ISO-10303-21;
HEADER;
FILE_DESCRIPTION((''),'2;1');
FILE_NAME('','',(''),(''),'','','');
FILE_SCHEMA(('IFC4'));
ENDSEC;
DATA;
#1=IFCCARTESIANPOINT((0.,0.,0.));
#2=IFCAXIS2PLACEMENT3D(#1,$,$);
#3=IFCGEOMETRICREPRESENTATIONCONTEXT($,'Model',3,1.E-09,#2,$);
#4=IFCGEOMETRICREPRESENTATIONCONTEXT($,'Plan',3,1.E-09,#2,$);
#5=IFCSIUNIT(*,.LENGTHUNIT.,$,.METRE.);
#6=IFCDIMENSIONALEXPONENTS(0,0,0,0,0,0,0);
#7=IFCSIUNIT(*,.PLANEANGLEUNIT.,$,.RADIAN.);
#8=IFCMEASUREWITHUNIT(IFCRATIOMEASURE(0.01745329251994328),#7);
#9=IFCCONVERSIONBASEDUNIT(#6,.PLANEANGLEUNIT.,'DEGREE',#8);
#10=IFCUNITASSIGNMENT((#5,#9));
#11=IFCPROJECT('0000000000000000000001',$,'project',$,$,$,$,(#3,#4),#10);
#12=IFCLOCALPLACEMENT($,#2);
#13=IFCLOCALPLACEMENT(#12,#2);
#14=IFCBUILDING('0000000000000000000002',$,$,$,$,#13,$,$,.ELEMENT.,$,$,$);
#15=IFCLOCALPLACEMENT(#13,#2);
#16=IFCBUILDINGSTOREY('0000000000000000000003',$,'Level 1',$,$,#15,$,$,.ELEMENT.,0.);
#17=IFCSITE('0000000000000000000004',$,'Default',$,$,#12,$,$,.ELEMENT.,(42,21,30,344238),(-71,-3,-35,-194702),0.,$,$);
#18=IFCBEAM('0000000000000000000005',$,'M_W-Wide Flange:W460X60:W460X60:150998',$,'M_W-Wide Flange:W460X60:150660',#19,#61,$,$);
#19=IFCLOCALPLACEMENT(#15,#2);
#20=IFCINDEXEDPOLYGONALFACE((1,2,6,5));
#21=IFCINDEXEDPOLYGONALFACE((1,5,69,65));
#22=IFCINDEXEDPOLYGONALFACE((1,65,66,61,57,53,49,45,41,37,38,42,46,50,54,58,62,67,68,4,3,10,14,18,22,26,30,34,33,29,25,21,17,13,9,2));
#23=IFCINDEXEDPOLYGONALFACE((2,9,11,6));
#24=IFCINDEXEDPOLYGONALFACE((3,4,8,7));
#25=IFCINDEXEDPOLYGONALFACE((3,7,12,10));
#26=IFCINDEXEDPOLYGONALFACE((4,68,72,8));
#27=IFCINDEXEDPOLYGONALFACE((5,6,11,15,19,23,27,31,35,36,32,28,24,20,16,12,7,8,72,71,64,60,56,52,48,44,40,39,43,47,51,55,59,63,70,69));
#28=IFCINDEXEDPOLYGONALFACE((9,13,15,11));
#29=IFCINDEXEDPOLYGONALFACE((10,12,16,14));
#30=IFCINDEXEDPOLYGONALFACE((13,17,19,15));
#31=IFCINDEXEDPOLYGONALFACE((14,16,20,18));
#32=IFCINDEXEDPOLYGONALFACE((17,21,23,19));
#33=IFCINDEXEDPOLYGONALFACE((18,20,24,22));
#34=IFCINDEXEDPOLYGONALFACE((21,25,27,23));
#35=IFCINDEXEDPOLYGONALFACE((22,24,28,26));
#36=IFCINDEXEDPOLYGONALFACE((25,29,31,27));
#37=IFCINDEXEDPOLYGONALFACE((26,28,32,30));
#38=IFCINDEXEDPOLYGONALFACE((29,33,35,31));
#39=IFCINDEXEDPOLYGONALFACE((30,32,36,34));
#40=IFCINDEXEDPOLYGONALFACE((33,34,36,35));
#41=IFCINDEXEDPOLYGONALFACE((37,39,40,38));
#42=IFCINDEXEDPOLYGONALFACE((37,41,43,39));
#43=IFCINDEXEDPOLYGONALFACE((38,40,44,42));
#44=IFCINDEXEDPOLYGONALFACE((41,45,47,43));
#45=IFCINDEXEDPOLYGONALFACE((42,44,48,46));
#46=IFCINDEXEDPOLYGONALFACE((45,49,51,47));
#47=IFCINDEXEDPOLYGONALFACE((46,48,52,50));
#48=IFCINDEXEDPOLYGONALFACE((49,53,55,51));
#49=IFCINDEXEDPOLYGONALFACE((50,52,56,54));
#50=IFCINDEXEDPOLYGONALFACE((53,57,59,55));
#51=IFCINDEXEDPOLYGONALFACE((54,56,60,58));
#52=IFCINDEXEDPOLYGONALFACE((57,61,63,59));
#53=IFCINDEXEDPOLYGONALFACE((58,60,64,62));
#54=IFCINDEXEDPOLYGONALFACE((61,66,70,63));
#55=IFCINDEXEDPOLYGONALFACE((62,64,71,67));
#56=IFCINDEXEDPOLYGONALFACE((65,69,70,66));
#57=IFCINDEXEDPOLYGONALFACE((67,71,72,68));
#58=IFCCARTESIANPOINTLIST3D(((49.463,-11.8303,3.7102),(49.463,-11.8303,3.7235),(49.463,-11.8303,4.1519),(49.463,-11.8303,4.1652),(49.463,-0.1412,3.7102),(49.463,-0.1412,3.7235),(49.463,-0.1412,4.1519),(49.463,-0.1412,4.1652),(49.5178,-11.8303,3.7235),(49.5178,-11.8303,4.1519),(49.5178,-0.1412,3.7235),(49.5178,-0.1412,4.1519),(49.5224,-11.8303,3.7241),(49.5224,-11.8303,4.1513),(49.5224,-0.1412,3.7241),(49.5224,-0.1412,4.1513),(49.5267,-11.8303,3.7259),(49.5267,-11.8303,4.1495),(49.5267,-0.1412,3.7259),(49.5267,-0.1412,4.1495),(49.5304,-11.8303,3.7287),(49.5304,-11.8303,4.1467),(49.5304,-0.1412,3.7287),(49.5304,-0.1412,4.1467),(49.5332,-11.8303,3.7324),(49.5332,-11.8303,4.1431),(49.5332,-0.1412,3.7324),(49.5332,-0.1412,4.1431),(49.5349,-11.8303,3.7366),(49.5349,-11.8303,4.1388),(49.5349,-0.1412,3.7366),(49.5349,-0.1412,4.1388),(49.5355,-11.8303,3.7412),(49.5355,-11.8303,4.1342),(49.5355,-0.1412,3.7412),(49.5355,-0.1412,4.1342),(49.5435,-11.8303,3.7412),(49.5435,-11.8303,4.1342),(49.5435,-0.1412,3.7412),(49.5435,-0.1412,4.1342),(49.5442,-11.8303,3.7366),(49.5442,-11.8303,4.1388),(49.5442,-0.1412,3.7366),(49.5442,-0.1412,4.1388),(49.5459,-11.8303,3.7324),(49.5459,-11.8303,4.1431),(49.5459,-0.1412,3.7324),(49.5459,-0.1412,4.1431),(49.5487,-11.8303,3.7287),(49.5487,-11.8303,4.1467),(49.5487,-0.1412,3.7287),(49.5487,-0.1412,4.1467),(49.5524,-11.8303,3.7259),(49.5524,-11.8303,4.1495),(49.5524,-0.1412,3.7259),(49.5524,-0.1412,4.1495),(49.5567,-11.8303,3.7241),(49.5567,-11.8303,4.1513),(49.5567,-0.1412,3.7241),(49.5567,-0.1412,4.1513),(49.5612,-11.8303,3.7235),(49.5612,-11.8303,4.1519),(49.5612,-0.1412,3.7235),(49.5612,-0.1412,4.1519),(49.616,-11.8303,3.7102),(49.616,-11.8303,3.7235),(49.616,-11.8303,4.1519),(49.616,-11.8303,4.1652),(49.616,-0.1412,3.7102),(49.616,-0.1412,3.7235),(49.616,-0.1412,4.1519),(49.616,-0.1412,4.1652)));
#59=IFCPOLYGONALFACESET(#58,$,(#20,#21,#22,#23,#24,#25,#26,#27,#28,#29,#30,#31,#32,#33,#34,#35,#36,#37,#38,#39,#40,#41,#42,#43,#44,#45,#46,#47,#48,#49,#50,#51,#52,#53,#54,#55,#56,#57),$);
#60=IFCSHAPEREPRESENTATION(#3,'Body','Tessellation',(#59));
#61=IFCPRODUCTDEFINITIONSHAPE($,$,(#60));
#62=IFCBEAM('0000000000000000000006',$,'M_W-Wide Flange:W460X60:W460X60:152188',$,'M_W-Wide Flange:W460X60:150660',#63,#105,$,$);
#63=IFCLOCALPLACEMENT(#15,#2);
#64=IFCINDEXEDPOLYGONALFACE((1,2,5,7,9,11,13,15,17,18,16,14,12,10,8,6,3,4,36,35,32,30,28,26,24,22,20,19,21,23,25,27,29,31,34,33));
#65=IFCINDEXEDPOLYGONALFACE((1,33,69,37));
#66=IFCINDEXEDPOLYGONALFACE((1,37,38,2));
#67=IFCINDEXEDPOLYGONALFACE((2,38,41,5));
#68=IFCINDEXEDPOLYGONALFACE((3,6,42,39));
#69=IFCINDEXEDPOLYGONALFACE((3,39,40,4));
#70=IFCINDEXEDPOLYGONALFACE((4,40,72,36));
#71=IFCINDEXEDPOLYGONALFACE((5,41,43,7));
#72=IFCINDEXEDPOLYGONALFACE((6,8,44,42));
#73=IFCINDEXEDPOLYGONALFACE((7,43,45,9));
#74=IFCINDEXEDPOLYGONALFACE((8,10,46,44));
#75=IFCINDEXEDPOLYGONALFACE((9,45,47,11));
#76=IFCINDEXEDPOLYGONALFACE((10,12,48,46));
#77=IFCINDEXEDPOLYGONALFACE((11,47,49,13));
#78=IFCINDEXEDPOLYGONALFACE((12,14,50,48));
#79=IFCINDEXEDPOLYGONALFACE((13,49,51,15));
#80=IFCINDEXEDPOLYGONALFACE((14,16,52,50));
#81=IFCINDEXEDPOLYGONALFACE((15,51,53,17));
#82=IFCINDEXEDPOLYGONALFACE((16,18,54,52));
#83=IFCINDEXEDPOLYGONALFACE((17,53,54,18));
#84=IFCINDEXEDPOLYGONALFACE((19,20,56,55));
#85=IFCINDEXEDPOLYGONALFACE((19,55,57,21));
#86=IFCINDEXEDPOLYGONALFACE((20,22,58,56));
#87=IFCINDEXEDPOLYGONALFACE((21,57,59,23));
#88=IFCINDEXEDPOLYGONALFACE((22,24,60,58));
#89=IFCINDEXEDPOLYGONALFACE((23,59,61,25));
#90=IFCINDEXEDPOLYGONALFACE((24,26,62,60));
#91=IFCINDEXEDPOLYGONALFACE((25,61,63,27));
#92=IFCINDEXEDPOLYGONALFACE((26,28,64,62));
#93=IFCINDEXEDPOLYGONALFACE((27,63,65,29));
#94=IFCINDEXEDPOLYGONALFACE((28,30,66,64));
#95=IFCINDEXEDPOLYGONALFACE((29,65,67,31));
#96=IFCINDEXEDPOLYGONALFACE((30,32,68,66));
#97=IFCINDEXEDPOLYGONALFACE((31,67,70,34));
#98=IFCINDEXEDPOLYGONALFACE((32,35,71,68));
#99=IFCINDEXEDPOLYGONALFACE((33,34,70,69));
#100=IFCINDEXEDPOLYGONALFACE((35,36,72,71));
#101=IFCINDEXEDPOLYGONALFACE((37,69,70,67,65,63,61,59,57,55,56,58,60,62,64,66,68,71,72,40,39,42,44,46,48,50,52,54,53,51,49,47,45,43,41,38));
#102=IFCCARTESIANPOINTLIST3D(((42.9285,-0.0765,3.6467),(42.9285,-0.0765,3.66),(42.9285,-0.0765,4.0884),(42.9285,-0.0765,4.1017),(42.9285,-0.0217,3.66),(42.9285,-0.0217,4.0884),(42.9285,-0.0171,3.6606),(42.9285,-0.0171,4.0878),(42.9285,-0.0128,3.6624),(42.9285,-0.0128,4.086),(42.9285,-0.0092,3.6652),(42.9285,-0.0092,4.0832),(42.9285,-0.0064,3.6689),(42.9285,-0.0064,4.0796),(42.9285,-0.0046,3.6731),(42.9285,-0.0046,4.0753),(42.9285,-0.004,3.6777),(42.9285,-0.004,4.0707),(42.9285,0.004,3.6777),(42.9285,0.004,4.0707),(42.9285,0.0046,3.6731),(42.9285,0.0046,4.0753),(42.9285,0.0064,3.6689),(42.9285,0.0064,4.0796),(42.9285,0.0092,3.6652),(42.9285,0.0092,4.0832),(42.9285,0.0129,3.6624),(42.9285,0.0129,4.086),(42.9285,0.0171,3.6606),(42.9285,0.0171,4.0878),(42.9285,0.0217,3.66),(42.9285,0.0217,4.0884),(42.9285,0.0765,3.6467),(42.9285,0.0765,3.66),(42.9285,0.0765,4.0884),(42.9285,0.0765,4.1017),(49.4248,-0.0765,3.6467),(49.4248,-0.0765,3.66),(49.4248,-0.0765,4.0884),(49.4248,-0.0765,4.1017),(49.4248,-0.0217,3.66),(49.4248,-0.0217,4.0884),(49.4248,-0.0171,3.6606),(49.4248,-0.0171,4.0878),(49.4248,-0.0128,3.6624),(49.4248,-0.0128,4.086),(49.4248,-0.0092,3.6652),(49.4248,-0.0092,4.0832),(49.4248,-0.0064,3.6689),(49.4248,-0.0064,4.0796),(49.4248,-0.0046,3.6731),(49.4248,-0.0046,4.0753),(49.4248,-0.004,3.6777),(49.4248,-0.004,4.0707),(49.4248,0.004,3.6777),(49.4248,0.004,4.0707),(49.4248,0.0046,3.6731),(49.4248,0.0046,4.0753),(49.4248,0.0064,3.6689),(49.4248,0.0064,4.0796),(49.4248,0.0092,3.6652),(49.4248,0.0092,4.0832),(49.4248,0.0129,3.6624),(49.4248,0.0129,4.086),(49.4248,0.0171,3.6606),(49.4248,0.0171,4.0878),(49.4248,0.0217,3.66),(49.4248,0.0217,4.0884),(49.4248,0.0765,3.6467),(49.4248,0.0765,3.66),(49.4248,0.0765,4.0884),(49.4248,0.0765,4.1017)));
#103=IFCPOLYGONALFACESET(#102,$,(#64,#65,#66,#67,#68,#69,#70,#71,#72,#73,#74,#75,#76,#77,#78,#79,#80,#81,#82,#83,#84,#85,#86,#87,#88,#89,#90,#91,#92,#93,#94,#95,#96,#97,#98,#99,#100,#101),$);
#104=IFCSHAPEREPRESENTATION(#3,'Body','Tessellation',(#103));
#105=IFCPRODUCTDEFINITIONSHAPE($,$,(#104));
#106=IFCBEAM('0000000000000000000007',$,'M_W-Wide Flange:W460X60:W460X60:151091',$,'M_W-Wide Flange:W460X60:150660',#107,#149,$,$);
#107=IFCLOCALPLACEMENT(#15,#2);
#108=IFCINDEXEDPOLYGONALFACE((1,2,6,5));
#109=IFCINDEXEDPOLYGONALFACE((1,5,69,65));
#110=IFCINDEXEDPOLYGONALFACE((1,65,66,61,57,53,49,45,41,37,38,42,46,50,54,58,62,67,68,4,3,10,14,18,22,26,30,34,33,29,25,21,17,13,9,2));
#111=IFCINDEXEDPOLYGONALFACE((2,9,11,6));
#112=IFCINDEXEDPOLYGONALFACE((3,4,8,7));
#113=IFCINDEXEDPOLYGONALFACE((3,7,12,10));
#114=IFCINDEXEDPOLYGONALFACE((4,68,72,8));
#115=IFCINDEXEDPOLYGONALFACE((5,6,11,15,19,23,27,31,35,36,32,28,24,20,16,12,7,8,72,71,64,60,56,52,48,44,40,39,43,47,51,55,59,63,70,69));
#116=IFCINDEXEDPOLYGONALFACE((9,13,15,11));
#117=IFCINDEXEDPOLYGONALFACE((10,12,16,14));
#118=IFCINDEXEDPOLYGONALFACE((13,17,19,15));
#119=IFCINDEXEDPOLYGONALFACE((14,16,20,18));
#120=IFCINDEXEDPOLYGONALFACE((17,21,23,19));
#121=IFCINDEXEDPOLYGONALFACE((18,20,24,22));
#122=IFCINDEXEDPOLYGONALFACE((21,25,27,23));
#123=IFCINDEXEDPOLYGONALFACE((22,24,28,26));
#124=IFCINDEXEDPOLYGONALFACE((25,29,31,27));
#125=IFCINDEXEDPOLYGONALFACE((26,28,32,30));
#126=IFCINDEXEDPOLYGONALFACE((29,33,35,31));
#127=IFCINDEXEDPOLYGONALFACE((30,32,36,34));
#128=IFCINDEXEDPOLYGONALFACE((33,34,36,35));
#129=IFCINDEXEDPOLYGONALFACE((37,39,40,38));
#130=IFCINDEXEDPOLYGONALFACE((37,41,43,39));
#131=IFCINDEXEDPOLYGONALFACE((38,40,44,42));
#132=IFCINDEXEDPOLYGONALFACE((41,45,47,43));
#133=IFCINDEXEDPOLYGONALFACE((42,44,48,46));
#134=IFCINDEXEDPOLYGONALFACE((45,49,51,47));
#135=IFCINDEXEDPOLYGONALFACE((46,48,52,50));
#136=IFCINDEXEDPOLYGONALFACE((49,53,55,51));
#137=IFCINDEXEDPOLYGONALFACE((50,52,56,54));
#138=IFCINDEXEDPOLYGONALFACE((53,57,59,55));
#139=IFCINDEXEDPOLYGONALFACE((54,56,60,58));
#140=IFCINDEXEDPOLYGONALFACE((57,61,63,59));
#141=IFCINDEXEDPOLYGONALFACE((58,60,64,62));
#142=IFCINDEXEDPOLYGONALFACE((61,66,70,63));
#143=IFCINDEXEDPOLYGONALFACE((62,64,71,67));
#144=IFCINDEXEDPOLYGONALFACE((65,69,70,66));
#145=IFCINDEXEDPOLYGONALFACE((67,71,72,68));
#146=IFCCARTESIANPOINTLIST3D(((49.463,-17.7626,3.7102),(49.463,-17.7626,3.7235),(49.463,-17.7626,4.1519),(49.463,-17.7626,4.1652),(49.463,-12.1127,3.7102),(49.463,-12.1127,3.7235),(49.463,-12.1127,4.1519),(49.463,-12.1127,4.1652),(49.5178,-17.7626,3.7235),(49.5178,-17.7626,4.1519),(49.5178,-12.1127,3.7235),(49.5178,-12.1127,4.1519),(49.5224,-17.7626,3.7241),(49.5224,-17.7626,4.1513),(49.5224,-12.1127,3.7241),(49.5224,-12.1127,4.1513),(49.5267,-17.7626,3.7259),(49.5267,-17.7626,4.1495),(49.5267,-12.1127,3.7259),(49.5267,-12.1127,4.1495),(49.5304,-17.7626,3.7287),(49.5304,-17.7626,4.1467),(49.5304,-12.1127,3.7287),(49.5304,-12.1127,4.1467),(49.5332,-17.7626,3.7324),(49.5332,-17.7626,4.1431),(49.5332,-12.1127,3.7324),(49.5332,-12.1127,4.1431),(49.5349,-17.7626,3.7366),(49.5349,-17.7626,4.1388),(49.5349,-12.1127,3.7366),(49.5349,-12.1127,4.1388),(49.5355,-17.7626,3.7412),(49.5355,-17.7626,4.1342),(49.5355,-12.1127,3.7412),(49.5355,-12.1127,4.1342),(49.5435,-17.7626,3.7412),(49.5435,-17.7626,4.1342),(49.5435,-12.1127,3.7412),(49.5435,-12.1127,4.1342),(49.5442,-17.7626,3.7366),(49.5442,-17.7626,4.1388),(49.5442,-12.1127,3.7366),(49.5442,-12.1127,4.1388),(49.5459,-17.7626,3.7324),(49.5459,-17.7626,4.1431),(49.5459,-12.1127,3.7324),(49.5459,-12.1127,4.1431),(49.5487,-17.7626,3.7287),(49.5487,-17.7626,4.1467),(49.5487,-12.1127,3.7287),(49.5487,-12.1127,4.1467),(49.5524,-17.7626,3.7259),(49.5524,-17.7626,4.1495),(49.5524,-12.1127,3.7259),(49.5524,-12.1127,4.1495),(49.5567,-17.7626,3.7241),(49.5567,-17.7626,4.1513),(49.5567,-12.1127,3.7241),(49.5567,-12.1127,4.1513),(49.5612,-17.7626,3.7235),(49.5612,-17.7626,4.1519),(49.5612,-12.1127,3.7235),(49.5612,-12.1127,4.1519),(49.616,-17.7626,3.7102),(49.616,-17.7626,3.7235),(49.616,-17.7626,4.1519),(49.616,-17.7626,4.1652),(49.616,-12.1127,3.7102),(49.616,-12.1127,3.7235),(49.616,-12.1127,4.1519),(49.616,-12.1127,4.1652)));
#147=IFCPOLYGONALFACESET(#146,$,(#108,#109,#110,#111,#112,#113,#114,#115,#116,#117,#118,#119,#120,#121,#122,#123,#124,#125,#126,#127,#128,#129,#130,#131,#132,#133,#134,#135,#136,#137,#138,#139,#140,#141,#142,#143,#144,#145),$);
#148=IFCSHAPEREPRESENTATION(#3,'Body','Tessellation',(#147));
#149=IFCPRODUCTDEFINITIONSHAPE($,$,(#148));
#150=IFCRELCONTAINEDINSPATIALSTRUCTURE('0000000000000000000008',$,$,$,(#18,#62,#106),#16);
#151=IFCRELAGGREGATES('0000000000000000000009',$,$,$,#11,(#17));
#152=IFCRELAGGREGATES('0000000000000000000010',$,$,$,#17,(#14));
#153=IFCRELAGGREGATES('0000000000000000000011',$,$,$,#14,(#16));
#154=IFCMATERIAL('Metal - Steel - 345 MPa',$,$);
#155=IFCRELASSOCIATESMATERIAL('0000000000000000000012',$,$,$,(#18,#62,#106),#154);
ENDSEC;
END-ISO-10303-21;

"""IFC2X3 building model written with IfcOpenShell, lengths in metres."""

from ifc_helpers import new_model, entity, si_unit, converted_unit, frame, frame_2d, origin, place, context, project, spatial, polyline, circle_curve, parameter, trimmed, segment, composite_curve, outline, extrude, material, element, save


model = new_model("IFC2X3")

# Units and contexts
model_context = context("Model", 3, precision=1e-09, world=origin())
plan_context = context("Plan", 3, precision=1e-09, world=origin())
ifc_project = project(units=[si_unit("LENGTHUNIT", "METRE"), converted_unit("PLANEANGLEUNIT", "DEGREE", entity("IfcRatioMeasure", 0.01745329251994328), si_unit("PLANEANGLEUNIT", "RADIAN"), dimensions=[0, 0, 0, 0, 0, 0, 0])], contexts=[model_context, plan_context])

# Site, building, storey
site_placement = place(None, origin())
site = spatial("IfcSite", under=ifc_project, at=site_placement, Name="Default", CompositionType="ELEMENT", RefLatitude=(42, 21, 30, 344238), RefLongitude=(-71, -3, -35, -194702), RefElevation=0.0)
building_placement = place(site_placement, origin())
building = spatial("IfcBuilding", under=site, at=building_placement, CompositionType="ELEMENT")
storey_placement = place(building_placement, origin())
storey = spatial("IfcBuildingStorey", under=building, at=storey_placement, Name="Level 1", CompositionType="ELEMENT", Elevation=0.0)

# Beams
ifc_material = material(Name="Metal - Steel - 345 MPa")
beam_1_placement = place(storey_placement, frame((49.5395, 0.0, 4.2672), z_axis=(0.0, 0.0, 1.0), x_axis=(-1.0, 0.0, 0.0)))
element("IfcBeam", 1, at=beam_1_placement, inside=storey, material=ifc_material, Name="M_W-Wide Flange:W460X60:W460X60:150998", ObjectType="M_W-Wide Flange:W460X60:150660", context=model_context, shape_type="SweptSolid", body=[
    extrude(outline(composite_curve([segment(polyline([(0.2142, -0.0765), (0.2275, -0.0765)]), True, "CONTINUOUS"), segment(polyline([(0.2275, -0.0765), (0.2275, 0.0765)]), True, "CONTINUOUS"), segment(polyline([(0.2275, 0.0765), (0.2142, 0.0765)]), True, "CONTINUOUS"), segment(polyline([(0.2142, 0.0765), (0.2142, 0.0217)]), True, "CONTINUOUS"), segment(trimmed(circle_curve(frame_2d((0.1965, 0.0217), x_axis=(0.0, 1.0)), 0.0177), [parameter(180.0)], [parameter(270.0)], True, "PARAMETER"), False, "CONTINUOUS"), segment(polyline([(0.1965, 0.004), (-0.1965, 0.004)]), True, "CONTINUOUS"), segment(trimmed(circle_curve(frame_2d((-0.1965, 0.0217), x_axis=(0.0, 1.0)), 0.0177), [parameter(90.0)], [parameter(180.0)], True, "PARAMETER"), False, "CONTINUOUS"), segment(polyline([(-0.2142, 0.0217), (-0.2142, 0.0765)]), True, "CONTINUOUS"), segment(polyline([(-0.2142, 0.0765), (-0.2275, 0.0765)]), True, "CONTINUOUS"), segment(polyline([(-0.2275, 0.0765), (-0.2275, -0.0765)]), True, "CONTINUOUS"), segment(polyline([(-0.2275, -0.0765), (-0.2142, -0.0765)]), True, "CONTINUOUS"), segment(polyline([(-0.2142, -0.0765), (-0.2142, -0.0217)]), True, "CONTINUOUS"), segment(trimmed(circle_curve(frame_2d((-0.1965, -0.0217), x_axis=(0.0, 1.0)), 0.0177), [parameter(360.0)], [parameter(90.0)], True, "PARAMETER"), False, "CONTINUOUS"), segment(polyline([(-0.1965, -0.004), (0.1965, -0.004)]), True, "CONTINUOUS"), segment(trimmed(circle_curve(frame_2d((0.1965, -0.0217), x_axis=(0.0, 1.0)), 0.0177), [parameter(270.0)], [parameter(0.0)], True, "PARAMETER"), False, "CONTINUOUS"), segment(polyline([(0.2142, -0.0217), (0.2142, -0.0765)]), True, "CONTINUOUS")], self_intersect=False)), frame((0.0, 11.8303, -0.3295), z_axis=(0.0, -1.0, 0.0), x_axis=(0.0, 0.0, -1.0)), (0.0, 0.0, 1.0), 11.6891),
])
beam_2_placement = place(storey_placement, frame((42.8138, 0.0, 4.2672), z_axis=(0.0, 0.0, 1.0), x_axis=(0.0, -1.0, 0.0)))
element("IfcBeam", 2, at=beam_2_placement, inside=storey, material=ifc_material, Name="M_W-Wide Flange:W460X60:W460X60:152188", ObjectType="M_W-Wide Flange:W460X60:150660", context=model_context, shape_type="SweptSolid", body=[
    extrude(outline(composite_curve([segment(polyline([(-0.0765, -0.2142), (-0.0765, -0.2275)]), True, "CONTINUOUS"), segment(polyline([(-0.0765, -0.2275), (0.0765, -0.2275)]), True, "CONTINUOUS"), segment(polyline([(0.0765, -0.2275), (0.0765, -0.2142)]), True, "CONTINUOUS"), segment(polyline([(0.0765, -0.2142), (0.0217, -0.2142)]), True, "CONTINUOUS"), segment(trimmed(circle_curve(frame_2d((0.0217, -0.1965), x_axis=(1.0, 0.0)), 0.0177), [parameter(180.0)], [parameter(270.0)], True, "PARAMETER"), False, "CONTINUOUS"), segment(polyline([(0.004, -0.1965), (0.004, 0.1965)]), True, "CONTINUOUS"), segment(trimmed(circle_curve(frame_2d((0.0217, 0.1965), x_axis=(1.0, 0.0)), 0.0177), [parameter(90.0)], [parameter(180.0)], True, "PARAMETER"), False, "CONTINUOUS"), segment(polyline([(0.0217, 0.2142), (0.0765, 0.2142)]), True, "CONTINUOUS"), segment(polyline([(0.0765, 0.2142), (0.0765, 0.2275)]), True, "CONTINUOUS"), segment(polyline([(0.0765, 0.2275), (-0.0765, 0.2275)]), True, "CONTINUOUS"), segment(polyline([(-0.0765, 0.2275), (-0.0765, 0.2142)]), True, "CONTINUOUS"), segment(polyline([(-0.0765, 0.2142), (-0.0217, 0.2142)]), True, "CONTINUOUS"), segment(trimmed(circle_curve(frame_2d((-0.0217, 0.1965), x_axis=(1.0, 0.0)), 0.0177), [parameter(360.0)], [parameter(90.0)], True, "PARAMETER"), False, "CONTINUOUS"), segment(polyline([(-0.004, 0.1965), (-0.004, -0.1965)]), True, "CONTINUOUS"), segment(trimmed(circle_curve(frame_2d((-0.0217, -0.1965), x_axis=(1.0, 0.0)), 0.0177), [parameter(270.0)], [parameter(0.0)], True, "PARAMETER"), False, "CONTINUOUS"), segment(polyline([(-0.0217, -0.2142), (-0.0765, -0.2142)]), True, "CONTINUOUS")], self_intersect=False)), frame((0.0, 0.1147, -0.393), z_axis=(0.0, -1.0, 0.0), x_axis=(1.0, 0.0, 0.0)), (0.0, 0.0, -1.0), 6.4963),
])
beam_3_placement = place(storey_placement, frame((49.5395, -11.9715, 4.2672), z_axis=(0.0, 0.0, 1.0), x_axis=(-1.0, 0.0, 0.0)))
element("IfcBeam", 3, at=beam_3_placement, inside=storey, material=ifc_material, Name="M_W-Wide Flange:W460X60:W460X60:151091", ObjectType="M_W-Wide Flange:W460X60:150660", context=model_context, shape_type="SweptSolid", body=[
    extrude(outline(composite_curve([segment(polyline([(0.2142, -0.0765), (0.2275, -0.0765)]), True, "CONTINUOUS"), segment(polyline([(0.2275, -0.0765), (0.2275, 0.0765)]), True, "CONTINUOUS"), segment(polyline([(0.2275, 0.0765), (0.2142, 0.0765)]), True, "CONTINUOUS"), segment(polyline([(0.2142, 0.0765), (0.2142, 0.0217)]), True, "CONTINUOUS"), segment(trimmed(circle_curve(frame_2d((0.1965, 0.0217), x_axis=(0.0, 1.0)), 0.0177), [parameter(180.0)], [parameter(270.0)], True, "PARAMETER"), False, "CONTINUOUS"), segment(polyline([(0.1965, 0.004), (-0.1965, 0.004)]), True, "CONTINUOUS"), segment(trimmed(circle_curve(frame_2d((-0.1965, 0.0217), x_axis=(0.0, 1.0)), 0.0177), [parameter(90.0)], [parameter(180.0)], True, "PARAMETER"), False, "CONTINUOUS"), segment(polyline([(-0.2142, 0.0217), (-0.2142, 0.0765)]), True, "CONTINUOUS"), segment(polyline([(-0.2142, 0.0765), (-0.2275, 0.0765)]), True, "CONTINUOUS"), segment(polyline([(-0.2275, 0.0765), (-0.2275, -0.0765)]), True, "CONTINUOUS"), segment(polyline([(-0.2275, -0.0765), (-0.2142, -0.0765)]), True, "CONTINUOUS"), segment(polyline([(-0.2142, -0.0765), (-0.2142, -0.0217)]), True, "CONTINUOUS"), segment(trimmed(circle_curve(frame_2d((-0.1965, -0.0217), x_axis=(0.0, 1.0)), 0.0177), [parameter(360.0)], [parameter(90.0)], True, "PARAMETER"), False, "CONTINUOUS"), segment(polyline([(-0.1965, -0.004), (0.1965, -0.004)]), True, "CONTINUOUS"), segment(trimmed(circle_curve(frame_2d((0.1965, -0.0217), x_axis=(0.0, 1.0)), 0.0177), [parameter(270.0)], [parameter(0.0)], True, "PARAMETER"), False, "CONTINUOUS"), segment(polyline([(0.2142, -0.0217), (0.2142, -0.0765)]), True, "CONTINUOUS")], self_intersect=False)), frame((0.0, 5.7912, -0.3295), z_axis=(0.0, -1.0, 0.0), x_axis=(0.0, 0.0, -1.0)), (0.0, 0.0, 1.0), 5.65),
])

save(model, "model.ifc")
